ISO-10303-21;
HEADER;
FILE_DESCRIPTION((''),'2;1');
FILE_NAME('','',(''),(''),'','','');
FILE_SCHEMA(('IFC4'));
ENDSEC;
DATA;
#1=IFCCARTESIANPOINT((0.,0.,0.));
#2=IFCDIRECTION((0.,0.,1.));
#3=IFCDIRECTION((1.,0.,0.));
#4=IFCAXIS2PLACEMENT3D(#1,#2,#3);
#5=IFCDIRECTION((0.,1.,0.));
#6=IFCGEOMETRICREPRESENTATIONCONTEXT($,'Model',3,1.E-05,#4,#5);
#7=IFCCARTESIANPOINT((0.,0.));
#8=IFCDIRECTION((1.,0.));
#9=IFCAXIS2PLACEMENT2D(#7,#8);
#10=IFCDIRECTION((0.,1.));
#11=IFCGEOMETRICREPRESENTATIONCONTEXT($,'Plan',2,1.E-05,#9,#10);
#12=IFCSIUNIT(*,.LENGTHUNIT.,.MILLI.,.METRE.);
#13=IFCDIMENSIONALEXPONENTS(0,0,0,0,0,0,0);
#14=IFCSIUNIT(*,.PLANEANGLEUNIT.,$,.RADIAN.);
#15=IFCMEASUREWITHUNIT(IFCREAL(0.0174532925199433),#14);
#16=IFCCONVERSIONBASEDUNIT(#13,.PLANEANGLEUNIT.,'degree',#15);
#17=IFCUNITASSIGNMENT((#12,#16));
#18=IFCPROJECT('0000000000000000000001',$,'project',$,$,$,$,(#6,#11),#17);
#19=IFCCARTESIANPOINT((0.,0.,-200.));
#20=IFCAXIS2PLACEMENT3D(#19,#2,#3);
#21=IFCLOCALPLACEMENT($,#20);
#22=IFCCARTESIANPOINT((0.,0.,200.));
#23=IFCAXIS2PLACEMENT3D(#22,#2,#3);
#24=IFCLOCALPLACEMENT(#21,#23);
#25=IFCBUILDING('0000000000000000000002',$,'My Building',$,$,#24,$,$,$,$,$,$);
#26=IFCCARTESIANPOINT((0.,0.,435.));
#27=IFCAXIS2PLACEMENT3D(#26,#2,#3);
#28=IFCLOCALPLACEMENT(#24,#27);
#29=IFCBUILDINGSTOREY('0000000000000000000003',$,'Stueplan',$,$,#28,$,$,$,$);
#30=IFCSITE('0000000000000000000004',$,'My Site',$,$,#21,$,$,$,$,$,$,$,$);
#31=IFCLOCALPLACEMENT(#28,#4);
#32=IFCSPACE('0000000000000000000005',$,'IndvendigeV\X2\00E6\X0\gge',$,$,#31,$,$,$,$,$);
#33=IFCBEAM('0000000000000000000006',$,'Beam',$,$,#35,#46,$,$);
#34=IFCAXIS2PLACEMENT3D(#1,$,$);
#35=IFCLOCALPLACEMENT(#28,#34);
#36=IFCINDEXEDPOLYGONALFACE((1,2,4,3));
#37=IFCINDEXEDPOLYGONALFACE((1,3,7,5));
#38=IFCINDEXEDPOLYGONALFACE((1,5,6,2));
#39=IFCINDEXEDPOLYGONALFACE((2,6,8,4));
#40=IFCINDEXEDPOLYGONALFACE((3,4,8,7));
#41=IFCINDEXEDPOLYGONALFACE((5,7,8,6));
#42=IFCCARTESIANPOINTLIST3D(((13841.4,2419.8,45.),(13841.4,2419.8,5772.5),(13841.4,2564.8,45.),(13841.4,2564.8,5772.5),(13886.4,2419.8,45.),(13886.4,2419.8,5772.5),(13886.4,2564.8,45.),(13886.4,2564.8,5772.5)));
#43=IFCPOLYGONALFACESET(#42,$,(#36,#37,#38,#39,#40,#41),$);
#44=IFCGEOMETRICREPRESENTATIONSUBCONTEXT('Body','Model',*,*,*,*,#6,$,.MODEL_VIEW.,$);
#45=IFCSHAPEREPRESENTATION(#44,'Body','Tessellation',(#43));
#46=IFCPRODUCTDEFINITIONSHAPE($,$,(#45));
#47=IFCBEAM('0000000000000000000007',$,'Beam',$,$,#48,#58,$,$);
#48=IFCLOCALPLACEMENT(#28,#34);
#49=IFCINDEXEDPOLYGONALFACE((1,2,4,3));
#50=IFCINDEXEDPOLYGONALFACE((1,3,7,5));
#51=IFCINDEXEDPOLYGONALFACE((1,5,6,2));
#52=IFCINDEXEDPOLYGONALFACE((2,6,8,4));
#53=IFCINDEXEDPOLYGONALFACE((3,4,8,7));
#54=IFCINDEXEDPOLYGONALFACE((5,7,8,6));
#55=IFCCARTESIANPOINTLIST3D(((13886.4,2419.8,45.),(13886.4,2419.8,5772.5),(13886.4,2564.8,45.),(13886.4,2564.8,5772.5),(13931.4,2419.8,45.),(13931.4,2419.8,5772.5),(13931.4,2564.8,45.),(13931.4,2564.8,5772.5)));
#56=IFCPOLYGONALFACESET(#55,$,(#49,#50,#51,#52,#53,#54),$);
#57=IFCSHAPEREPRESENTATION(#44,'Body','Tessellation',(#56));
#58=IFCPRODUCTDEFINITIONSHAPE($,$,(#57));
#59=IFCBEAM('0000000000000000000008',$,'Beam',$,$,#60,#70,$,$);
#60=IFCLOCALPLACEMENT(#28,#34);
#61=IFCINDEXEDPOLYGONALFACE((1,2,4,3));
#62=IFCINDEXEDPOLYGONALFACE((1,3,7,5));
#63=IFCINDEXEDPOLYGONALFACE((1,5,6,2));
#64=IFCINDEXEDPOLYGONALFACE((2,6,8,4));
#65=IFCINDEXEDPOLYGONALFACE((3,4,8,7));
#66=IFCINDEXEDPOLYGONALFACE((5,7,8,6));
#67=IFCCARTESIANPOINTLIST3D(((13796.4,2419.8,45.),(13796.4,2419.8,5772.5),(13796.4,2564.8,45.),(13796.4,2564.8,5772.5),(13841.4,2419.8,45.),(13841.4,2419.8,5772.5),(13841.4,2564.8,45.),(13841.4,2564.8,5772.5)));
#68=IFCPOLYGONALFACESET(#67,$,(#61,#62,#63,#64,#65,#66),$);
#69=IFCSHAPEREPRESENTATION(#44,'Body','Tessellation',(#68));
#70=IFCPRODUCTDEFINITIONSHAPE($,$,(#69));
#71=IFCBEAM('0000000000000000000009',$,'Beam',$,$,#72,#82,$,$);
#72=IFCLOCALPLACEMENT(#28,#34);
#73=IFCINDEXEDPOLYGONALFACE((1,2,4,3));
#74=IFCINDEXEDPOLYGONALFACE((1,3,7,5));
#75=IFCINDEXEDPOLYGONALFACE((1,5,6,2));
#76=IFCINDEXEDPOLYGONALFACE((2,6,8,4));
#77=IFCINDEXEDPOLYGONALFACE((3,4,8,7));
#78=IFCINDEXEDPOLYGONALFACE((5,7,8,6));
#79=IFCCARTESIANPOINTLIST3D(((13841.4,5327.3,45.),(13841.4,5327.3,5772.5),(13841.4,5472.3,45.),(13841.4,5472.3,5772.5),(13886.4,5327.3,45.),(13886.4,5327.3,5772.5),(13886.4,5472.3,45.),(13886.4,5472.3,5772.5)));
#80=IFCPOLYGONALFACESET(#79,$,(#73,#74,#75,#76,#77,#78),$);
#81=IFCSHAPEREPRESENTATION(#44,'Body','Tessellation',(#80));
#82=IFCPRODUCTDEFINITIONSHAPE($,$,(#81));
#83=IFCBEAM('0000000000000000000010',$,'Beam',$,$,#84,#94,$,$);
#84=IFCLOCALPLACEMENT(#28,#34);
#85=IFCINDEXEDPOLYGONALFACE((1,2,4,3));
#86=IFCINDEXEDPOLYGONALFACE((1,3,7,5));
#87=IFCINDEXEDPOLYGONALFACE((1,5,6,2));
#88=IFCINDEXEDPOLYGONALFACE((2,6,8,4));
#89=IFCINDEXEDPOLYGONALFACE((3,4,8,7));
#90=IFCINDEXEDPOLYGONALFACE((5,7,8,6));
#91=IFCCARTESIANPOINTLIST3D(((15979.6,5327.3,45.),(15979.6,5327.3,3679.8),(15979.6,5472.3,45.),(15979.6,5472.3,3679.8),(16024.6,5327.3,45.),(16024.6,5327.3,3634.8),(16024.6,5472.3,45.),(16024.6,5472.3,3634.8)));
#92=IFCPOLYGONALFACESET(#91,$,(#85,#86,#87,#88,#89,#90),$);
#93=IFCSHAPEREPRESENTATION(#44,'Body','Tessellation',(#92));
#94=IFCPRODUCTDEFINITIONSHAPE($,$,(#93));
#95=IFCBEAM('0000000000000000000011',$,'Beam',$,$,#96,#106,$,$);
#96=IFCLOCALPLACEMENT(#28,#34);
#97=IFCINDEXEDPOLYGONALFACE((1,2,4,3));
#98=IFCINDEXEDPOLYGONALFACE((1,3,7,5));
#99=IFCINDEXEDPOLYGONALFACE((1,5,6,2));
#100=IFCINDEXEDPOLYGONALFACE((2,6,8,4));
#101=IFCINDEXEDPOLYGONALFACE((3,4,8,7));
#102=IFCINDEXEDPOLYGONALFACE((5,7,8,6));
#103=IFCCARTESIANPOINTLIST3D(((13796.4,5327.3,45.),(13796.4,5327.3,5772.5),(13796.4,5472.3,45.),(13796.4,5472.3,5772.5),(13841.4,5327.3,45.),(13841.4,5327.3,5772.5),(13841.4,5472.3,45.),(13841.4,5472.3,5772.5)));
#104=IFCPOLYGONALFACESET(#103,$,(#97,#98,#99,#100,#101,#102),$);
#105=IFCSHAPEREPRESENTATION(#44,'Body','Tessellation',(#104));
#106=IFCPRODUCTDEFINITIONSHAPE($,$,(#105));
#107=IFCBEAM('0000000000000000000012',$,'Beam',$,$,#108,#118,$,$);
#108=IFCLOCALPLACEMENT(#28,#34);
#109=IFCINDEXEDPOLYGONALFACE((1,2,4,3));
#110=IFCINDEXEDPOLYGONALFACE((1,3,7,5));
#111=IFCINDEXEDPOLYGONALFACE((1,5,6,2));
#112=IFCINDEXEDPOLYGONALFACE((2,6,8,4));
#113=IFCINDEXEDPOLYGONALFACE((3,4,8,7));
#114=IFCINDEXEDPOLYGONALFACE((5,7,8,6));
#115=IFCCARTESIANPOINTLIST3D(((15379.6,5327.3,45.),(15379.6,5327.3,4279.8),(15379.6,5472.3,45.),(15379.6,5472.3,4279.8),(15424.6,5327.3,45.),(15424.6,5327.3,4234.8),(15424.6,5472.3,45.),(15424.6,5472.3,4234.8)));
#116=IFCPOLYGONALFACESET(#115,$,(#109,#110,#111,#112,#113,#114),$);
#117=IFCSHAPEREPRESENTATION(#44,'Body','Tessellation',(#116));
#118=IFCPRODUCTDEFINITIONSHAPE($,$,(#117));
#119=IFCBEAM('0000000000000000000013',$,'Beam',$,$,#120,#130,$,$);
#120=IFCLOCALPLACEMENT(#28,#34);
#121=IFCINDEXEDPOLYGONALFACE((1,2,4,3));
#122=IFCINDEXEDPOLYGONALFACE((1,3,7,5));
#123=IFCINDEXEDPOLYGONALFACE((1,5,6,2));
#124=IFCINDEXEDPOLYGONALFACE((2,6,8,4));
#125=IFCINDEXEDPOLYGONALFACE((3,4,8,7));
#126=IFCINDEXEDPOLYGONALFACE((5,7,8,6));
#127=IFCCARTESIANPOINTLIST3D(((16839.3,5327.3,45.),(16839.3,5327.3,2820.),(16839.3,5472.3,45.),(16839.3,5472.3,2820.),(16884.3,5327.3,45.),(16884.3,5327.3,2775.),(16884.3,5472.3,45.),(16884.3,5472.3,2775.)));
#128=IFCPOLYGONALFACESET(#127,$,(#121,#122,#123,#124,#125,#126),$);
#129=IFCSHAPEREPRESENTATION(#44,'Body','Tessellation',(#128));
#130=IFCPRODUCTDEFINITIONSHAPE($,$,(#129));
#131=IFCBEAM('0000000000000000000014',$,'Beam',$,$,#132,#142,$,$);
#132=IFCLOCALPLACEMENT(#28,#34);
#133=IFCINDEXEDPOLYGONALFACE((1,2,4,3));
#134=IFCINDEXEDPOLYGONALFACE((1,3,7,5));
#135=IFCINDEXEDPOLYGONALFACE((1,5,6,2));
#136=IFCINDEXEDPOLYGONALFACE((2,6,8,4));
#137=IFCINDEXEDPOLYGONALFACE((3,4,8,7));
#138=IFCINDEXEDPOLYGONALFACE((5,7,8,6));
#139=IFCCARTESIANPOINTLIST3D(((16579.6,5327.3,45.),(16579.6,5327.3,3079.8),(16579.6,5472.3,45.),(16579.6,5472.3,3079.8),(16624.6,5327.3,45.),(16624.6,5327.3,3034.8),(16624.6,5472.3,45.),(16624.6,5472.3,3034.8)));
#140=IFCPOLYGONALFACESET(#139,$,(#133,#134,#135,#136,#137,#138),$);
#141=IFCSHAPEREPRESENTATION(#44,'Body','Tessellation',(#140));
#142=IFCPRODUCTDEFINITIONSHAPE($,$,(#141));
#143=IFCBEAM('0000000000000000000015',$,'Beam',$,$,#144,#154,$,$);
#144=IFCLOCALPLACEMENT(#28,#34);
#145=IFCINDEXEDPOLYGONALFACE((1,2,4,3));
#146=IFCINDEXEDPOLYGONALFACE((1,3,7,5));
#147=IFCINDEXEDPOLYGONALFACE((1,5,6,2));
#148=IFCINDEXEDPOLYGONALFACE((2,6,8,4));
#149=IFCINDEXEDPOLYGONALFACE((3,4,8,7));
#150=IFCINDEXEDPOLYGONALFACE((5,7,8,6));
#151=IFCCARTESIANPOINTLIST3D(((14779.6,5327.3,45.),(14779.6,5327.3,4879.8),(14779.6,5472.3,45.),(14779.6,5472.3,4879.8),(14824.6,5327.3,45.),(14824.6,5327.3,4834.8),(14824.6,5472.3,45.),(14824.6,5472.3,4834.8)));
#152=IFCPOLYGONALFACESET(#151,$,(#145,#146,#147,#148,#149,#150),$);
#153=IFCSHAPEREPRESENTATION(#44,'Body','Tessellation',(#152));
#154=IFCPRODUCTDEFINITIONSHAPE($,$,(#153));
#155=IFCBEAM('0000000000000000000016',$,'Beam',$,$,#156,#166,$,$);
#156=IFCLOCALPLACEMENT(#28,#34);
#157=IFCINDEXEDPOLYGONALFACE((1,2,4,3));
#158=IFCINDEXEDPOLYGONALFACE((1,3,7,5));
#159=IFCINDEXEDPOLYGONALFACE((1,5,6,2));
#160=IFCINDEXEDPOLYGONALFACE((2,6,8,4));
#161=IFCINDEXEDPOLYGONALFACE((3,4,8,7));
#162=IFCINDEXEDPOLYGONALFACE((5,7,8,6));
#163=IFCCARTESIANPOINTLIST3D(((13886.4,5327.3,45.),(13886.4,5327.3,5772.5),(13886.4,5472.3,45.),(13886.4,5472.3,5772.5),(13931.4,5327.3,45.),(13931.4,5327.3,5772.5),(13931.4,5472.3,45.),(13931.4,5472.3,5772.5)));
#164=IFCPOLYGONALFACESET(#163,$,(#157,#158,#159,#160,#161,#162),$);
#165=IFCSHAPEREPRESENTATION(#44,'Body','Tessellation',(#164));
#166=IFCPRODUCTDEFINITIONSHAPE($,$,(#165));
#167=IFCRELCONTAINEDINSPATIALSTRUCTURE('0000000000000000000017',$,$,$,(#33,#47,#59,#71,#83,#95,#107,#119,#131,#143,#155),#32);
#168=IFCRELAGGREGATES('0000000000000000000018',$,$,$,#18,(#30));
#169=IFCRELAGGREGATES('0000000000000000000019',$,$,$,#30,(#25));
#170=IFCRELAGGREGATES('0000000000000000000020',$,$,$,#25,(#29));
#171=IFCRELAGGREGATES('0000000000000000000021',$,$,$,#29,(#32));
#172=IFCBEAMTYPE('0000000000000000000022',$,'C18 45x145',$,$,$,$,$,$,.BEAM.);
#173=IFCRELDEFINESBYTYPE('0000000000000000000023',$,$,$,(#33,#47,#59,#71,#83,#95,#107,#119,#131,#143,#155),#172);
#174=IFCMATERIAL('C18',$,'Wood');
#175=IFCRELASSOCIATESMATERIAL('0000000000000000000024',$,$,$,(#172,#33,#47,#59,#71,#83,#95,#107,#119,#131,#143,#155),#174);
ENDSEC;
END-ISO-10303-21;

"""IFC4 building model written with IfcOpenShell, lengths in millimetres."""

from ifc_helpers import new_model, entity, si_unit, converted_unit, direction, frame, origin_with_axes, origin_2d_with_axis, place, context, subcontext, project, spatial, rectangle, extrude, clip, halfspace, material, material_profile, profile_set, profile_usage, type_object, element, save


model = new_model("IFC4")

# Units and contexts
model_context = context("Model", 3, precision=1e-05, world=origin_with_axes(), true_north=direction((0.0, 1.0, 0.0)))
plan_context = context("Plan", 2, precision=1e-05, world=origin_2d_with_axis(), true_north=direction((0.0, 1.0)))
body_context_1 = subcontext(model_context, "Body", "Model", "MODEL_VIEW")
ifc_project = project(units=[si_unit("LENGTHUNIT", "METRE", prefix="MILLI"), converted_unit("PLANEANGLEUNIT", "degree", entity("IfcReal", 0.0174532925199433), si_unit("PLANEANGLEUNIT", "RADIAN"), dimensions=[0, 0, 0, 0, 0, 0, 0])], contexts=[model_context, plan_context])

# Site, building, storey
site_placement = place(None, frame((0.0, 0.0, -200.0), z_axis=(0.0, 0.0, 1.0), x_axis=(1.0, 0.0, 0.0)))
site = spatial("IfcSite", under=ifc_project, at=site_placement, Name="My Site")
building_placement = place(site_placement, frame((0.0, 0.0, 200.0), z_axis=(0.0, 0.0, 1.0), x_axis=(1.0, 0.0, 0.0)))
building = spatial("IfcBuilding", under=site, at=building_placement, Name="My Building")
storey_placement = place(building_placement, frame((0.0, 0.0, 435.0), z_axis=(0.0, 0.0, 1.0), x_axis=(1.0, 0.0, 0.0)))
storey = spatial("IfcBuildingStorey", under=building, at=storey_placement, Name="Stueplan")

# Shared definitions
ifc_material = material(Name="C18", Category="Wood")

# Shared definitions
space_1_placement = place(storey_placement, frame((0.0, 0.0, 0.0), z_axis=(0.0, 0.0, 1.0), x_axis=(1.0, 0.0, 0.0)))
space_1 = spatial("IfcSpace", under=storey, at=space_1_placement, Name="IndvendigeVægge")

# Beams
ifc_material_profile_1 = material_profile(ifc_material, rectangle(XDim=45.0, YDim=145.0))
ifc_profile_set_1 = profile_set([ifc_material_profile_1], Name="woodStructural")
beam_type_1 = type_object("IfcBeamType", Name="C18 45x145", PredefinedType="BEAM", material=ifc_profile_set_1)
ifc_profile_usage_1 = profile_usage(ifc_profile_set_1)
beam_1_placement = place(space_1_placement, frame((13863.9, 2492.3, 45.0), z_axis=(0.0, 0.0, 1.0), x_axis=(-1.0, 0.0, 0.0)))
element("IfcBeam", 1, at=beam_1_placement, inside=space_1, type_object=beam_type_1, material=ifc_profile_usage_1, Name="Beam", context=body_context_1, shape_type="SweptSolid", body=[
    extrude(rectangle(XDim=45.0, YDim=145.0), origin_with_axes(), (0.0, 0.0, 1.0), 5727.5),
])
ifc_profile_usage_2 = profile_usage(ifc_profile_set_1)
beam_2_placement = place(space_1_placement, frame((13908.9, 2492.3, 45.0), z_axis=(0.0, 0.0, 1.0), x_axis=(-1.0, 0.0, 0.0)))
element("IfcBeam", 2, at=beam_2_placement, inside=space_1, type_object=beam_type_1, material=ifc_profile_usage_2, Name="Beam", context=body_context_1, shape_type="SweptSolid", body=[
    extrude(rectangle(XDim=45.0, YDim=145.0), origin_with_axes(), (0.0, 0.0, 1.0), 5727.5),
])
ifc_profile_usage_3 = profile_usage(ifc_profile_set_1)
beam_3_placement = place(space_1_placement, frame((13818.9, 2492.3, 45.0), z_axis=(0.0, 0.0, 1.0), x_axis=(-1.0, 0.0, 0.0)))
element("IfcBeam", 3, at=beam_3_placement, inside=space_1, type_object=beam_type_1, material=ifc_profile_usage_3, Name="Beam", context=body_context_1, shape_type="SweptSolid", body=[
    extrude(rectangle(XDim=45.0, YDim=145.0), origin_with_axes(), (0.0, 0.0, 1.0), 5727.5),
])
ifc_profile_usage_4 = profile_usage(ifc_profile_set_1)
beam_4_placement = place(space_1_placement, frame((13863.9, 5399.8, 45.0), z_axis=(0.0, 0.0, 1.0), x_axis=(-1.0, 0.0, 0.0)))
element("IfcBeam", 4, at=beam_4_placement, inside=space_1, type_object=beam_type_1, material=ifc_profile_usage_4, Name="Beam", context=body_context_1, shape_type="SweptSolid", body=[
    extrude(rectangle(XDim=45.0, YDim=145.0), origin_with_axes(), (0.0, 0.0, 1.0), 5727.5),
])
ifc_profile_usage_5 = profile_usage(ifc_profile_set_1)
beam_5_placement = place(space_1_placement, frame((16002.1, 5399.8, 45.0), z_axis=(0.0, 0.0, 1.0), x_axis=(-1.0, 0.0, 0.0)))
element("IfcBeam", 5, at=beam_5_placement, inside=space_1, type_object=beam_type_1, material=ifc_profile_usage_5, Name="Beam", context=body_context_1, shape_type="Clipping", body=[
    clip(extrude(rectangle(XDim=45.0, YDim=145.0), origin_with_axes(), (0.0, 0.0, 1.0), 3757.2), halfspace(frame((-968.8, 0.0, 2643.4), z_axis=(-0.707107, 0.0, 0.707106), x_axis=(0.0, 1.0, 0.0)), False)),
])
ifc_profile_usage_6 = profile_usage(ifc_profile_set_1)
beam_6_placement = place(space_1_placement, frame((13818.9, 5399.8, 45.0), z_axis=(0.0, 0.0, 1.0), x_axis=(-1.0, 0.0, 0.0)))
element("IfcBeam", 6, at=beam_6_placement, inside=space_1, type_object=beam_type_1, material=ifc_profile_usage_6, Name="Beam", context=body_context_1, shape_type="SweptSolid", body=[
    extrude(rectangle(XDim=45.0, YDim=145.0), origin_with_axes(), (0.0, 0.0, 1.0), 5727.5),
])
ifc_profile_usage_7 = profile_usage(ifc_profile_set_1)
beam_7_placement = place(space_1_placement, frame((15402.1, 5399.8, 45.0), z_axis=(0.0, 0.0, 1.0), x_axis=(-1.0, 0.0, 0.0)))
element("IfcBeam", 7, at=beam_7_placement, inside=space_1, type_object=beam_type_1, material=ifc_profile_usage_7, Name="Beam", context=body_context_1, shape_type="Clipping", body=[
    clip(extrude(rectangle(XDim=45.0, YDim=145.0), origin_with_axes(), (0.0, 0.0, 1.0), 4357.3), halfspace(frame((-1568.8, 0.0, 2643.4), z_axis=(-0.707107, 0.0, 0.707106), x_axis=(0.0, 1.0, 0.0)), False)),
])
ifc_profile_usage_8 = profile_usage(ifc_profile_set_1)
beam_8_placement = place(space_1_placement, frame((16861.8, 5399.8, 45.0), z_axis=(0.0, 0.0, 1.0), x_axis=(-1.0, 0.0, 0.0)))
element("IfcBeam", 8, at=beam_8_placement, inside=space_1, type_object=beam_type_1, material=ifc_profile_usage_8, Name="Beam", context=body_context_1, shape_type="Clipping", body=[
    clip(extrude(rectangle(XDim=45.0, YDim=145.0), origin_with_axes(), (0.0, 0.0, 1.0), 2897.5), halfspace(frame((-109.1, 0.0, 2643.4), z_axis=(-0.707107, 0.0, 0.707106), x_axis=(0.0, 1.0, 0.0)), False)),
])
ifc_profile_usage_9 = profile_usage(ifc_profile_set_1)
beam_9_placement = place(space_1_placement, frame((16602.1, 5399.8, 45.0), z_axis=(0.0, 0.0, 1.0), x_axis=(-1.0, 0.0, 0.0)))
element("IfcBeam", 9, at=beam_9_placement, inside=space_1, type_object=beam_type_1, material=ifc_profile_usage_9, Name="Beam", context=body_context_1, shape_type="Clipping", body=[
    clip(extrude(rectangle(XDim=45.0, YDim=145.0), origin_with_axes(), (0.0, 0.0, 1.0), 3157.3), halfspace(frame((-368.8, 0.0, 2643.4), z_axis=(-0.707107, 0.0, 0.707106), x_axis=(0.0, 1.0, 0.0)), False)),
])
ifc_profile_usage_10 = profile_usage(ifc_profile_set_1)
beam_10_placement = place(space_1_placement, frame((14802.1, 5399.8, 45.0), z_axis=(0.0, 0.0, 1.0), x_axis=(-1.0, 0.0, 0.0)))
element("IfcBeam", 10, at=beam_10_placement, inside=space_1, type_object=beam_type_1, material=ifc_profile_usage_10, Name="Beam", context=body_context_1, shape_type="Clipping", body=[
    clip(extrude(rectangle(XDim=45.0, YDim=145.0), origin_with_axes(), (0.0, 0.0, 1.0), 4957.3), halfspace(frame((-2168.8, 0.0, 2643.4), z_axis=(-0.707107, 0.0, 0.707106), x_axis=(0.0, 1.0, 0.0)), False)),
])
ifc_profile_usage_11 = profile_usage(ifc_profile_set_1)
beam_11_placement = place(space_1_placement, frame((13908.9, 5399.8, 45.0), z_axis=(0.0, 0.0, 1.0), x_axis=(-1.0, 0.0, 0.0)))
element("IfcBeam", 11, at=beam_11_placement, inside=space_1, type_object=beam_type_1, material=ifc_profile_usage_11, Name="Beam", context=body_context_1, shape_type="SweptSolid", body=[
    extrude(rectangle(XDim=45.0, YDim=145.0), origin_with_axes(), (0.0, 0.0, 1.0), 5727.5),
])

save(model, "model.ifc")
